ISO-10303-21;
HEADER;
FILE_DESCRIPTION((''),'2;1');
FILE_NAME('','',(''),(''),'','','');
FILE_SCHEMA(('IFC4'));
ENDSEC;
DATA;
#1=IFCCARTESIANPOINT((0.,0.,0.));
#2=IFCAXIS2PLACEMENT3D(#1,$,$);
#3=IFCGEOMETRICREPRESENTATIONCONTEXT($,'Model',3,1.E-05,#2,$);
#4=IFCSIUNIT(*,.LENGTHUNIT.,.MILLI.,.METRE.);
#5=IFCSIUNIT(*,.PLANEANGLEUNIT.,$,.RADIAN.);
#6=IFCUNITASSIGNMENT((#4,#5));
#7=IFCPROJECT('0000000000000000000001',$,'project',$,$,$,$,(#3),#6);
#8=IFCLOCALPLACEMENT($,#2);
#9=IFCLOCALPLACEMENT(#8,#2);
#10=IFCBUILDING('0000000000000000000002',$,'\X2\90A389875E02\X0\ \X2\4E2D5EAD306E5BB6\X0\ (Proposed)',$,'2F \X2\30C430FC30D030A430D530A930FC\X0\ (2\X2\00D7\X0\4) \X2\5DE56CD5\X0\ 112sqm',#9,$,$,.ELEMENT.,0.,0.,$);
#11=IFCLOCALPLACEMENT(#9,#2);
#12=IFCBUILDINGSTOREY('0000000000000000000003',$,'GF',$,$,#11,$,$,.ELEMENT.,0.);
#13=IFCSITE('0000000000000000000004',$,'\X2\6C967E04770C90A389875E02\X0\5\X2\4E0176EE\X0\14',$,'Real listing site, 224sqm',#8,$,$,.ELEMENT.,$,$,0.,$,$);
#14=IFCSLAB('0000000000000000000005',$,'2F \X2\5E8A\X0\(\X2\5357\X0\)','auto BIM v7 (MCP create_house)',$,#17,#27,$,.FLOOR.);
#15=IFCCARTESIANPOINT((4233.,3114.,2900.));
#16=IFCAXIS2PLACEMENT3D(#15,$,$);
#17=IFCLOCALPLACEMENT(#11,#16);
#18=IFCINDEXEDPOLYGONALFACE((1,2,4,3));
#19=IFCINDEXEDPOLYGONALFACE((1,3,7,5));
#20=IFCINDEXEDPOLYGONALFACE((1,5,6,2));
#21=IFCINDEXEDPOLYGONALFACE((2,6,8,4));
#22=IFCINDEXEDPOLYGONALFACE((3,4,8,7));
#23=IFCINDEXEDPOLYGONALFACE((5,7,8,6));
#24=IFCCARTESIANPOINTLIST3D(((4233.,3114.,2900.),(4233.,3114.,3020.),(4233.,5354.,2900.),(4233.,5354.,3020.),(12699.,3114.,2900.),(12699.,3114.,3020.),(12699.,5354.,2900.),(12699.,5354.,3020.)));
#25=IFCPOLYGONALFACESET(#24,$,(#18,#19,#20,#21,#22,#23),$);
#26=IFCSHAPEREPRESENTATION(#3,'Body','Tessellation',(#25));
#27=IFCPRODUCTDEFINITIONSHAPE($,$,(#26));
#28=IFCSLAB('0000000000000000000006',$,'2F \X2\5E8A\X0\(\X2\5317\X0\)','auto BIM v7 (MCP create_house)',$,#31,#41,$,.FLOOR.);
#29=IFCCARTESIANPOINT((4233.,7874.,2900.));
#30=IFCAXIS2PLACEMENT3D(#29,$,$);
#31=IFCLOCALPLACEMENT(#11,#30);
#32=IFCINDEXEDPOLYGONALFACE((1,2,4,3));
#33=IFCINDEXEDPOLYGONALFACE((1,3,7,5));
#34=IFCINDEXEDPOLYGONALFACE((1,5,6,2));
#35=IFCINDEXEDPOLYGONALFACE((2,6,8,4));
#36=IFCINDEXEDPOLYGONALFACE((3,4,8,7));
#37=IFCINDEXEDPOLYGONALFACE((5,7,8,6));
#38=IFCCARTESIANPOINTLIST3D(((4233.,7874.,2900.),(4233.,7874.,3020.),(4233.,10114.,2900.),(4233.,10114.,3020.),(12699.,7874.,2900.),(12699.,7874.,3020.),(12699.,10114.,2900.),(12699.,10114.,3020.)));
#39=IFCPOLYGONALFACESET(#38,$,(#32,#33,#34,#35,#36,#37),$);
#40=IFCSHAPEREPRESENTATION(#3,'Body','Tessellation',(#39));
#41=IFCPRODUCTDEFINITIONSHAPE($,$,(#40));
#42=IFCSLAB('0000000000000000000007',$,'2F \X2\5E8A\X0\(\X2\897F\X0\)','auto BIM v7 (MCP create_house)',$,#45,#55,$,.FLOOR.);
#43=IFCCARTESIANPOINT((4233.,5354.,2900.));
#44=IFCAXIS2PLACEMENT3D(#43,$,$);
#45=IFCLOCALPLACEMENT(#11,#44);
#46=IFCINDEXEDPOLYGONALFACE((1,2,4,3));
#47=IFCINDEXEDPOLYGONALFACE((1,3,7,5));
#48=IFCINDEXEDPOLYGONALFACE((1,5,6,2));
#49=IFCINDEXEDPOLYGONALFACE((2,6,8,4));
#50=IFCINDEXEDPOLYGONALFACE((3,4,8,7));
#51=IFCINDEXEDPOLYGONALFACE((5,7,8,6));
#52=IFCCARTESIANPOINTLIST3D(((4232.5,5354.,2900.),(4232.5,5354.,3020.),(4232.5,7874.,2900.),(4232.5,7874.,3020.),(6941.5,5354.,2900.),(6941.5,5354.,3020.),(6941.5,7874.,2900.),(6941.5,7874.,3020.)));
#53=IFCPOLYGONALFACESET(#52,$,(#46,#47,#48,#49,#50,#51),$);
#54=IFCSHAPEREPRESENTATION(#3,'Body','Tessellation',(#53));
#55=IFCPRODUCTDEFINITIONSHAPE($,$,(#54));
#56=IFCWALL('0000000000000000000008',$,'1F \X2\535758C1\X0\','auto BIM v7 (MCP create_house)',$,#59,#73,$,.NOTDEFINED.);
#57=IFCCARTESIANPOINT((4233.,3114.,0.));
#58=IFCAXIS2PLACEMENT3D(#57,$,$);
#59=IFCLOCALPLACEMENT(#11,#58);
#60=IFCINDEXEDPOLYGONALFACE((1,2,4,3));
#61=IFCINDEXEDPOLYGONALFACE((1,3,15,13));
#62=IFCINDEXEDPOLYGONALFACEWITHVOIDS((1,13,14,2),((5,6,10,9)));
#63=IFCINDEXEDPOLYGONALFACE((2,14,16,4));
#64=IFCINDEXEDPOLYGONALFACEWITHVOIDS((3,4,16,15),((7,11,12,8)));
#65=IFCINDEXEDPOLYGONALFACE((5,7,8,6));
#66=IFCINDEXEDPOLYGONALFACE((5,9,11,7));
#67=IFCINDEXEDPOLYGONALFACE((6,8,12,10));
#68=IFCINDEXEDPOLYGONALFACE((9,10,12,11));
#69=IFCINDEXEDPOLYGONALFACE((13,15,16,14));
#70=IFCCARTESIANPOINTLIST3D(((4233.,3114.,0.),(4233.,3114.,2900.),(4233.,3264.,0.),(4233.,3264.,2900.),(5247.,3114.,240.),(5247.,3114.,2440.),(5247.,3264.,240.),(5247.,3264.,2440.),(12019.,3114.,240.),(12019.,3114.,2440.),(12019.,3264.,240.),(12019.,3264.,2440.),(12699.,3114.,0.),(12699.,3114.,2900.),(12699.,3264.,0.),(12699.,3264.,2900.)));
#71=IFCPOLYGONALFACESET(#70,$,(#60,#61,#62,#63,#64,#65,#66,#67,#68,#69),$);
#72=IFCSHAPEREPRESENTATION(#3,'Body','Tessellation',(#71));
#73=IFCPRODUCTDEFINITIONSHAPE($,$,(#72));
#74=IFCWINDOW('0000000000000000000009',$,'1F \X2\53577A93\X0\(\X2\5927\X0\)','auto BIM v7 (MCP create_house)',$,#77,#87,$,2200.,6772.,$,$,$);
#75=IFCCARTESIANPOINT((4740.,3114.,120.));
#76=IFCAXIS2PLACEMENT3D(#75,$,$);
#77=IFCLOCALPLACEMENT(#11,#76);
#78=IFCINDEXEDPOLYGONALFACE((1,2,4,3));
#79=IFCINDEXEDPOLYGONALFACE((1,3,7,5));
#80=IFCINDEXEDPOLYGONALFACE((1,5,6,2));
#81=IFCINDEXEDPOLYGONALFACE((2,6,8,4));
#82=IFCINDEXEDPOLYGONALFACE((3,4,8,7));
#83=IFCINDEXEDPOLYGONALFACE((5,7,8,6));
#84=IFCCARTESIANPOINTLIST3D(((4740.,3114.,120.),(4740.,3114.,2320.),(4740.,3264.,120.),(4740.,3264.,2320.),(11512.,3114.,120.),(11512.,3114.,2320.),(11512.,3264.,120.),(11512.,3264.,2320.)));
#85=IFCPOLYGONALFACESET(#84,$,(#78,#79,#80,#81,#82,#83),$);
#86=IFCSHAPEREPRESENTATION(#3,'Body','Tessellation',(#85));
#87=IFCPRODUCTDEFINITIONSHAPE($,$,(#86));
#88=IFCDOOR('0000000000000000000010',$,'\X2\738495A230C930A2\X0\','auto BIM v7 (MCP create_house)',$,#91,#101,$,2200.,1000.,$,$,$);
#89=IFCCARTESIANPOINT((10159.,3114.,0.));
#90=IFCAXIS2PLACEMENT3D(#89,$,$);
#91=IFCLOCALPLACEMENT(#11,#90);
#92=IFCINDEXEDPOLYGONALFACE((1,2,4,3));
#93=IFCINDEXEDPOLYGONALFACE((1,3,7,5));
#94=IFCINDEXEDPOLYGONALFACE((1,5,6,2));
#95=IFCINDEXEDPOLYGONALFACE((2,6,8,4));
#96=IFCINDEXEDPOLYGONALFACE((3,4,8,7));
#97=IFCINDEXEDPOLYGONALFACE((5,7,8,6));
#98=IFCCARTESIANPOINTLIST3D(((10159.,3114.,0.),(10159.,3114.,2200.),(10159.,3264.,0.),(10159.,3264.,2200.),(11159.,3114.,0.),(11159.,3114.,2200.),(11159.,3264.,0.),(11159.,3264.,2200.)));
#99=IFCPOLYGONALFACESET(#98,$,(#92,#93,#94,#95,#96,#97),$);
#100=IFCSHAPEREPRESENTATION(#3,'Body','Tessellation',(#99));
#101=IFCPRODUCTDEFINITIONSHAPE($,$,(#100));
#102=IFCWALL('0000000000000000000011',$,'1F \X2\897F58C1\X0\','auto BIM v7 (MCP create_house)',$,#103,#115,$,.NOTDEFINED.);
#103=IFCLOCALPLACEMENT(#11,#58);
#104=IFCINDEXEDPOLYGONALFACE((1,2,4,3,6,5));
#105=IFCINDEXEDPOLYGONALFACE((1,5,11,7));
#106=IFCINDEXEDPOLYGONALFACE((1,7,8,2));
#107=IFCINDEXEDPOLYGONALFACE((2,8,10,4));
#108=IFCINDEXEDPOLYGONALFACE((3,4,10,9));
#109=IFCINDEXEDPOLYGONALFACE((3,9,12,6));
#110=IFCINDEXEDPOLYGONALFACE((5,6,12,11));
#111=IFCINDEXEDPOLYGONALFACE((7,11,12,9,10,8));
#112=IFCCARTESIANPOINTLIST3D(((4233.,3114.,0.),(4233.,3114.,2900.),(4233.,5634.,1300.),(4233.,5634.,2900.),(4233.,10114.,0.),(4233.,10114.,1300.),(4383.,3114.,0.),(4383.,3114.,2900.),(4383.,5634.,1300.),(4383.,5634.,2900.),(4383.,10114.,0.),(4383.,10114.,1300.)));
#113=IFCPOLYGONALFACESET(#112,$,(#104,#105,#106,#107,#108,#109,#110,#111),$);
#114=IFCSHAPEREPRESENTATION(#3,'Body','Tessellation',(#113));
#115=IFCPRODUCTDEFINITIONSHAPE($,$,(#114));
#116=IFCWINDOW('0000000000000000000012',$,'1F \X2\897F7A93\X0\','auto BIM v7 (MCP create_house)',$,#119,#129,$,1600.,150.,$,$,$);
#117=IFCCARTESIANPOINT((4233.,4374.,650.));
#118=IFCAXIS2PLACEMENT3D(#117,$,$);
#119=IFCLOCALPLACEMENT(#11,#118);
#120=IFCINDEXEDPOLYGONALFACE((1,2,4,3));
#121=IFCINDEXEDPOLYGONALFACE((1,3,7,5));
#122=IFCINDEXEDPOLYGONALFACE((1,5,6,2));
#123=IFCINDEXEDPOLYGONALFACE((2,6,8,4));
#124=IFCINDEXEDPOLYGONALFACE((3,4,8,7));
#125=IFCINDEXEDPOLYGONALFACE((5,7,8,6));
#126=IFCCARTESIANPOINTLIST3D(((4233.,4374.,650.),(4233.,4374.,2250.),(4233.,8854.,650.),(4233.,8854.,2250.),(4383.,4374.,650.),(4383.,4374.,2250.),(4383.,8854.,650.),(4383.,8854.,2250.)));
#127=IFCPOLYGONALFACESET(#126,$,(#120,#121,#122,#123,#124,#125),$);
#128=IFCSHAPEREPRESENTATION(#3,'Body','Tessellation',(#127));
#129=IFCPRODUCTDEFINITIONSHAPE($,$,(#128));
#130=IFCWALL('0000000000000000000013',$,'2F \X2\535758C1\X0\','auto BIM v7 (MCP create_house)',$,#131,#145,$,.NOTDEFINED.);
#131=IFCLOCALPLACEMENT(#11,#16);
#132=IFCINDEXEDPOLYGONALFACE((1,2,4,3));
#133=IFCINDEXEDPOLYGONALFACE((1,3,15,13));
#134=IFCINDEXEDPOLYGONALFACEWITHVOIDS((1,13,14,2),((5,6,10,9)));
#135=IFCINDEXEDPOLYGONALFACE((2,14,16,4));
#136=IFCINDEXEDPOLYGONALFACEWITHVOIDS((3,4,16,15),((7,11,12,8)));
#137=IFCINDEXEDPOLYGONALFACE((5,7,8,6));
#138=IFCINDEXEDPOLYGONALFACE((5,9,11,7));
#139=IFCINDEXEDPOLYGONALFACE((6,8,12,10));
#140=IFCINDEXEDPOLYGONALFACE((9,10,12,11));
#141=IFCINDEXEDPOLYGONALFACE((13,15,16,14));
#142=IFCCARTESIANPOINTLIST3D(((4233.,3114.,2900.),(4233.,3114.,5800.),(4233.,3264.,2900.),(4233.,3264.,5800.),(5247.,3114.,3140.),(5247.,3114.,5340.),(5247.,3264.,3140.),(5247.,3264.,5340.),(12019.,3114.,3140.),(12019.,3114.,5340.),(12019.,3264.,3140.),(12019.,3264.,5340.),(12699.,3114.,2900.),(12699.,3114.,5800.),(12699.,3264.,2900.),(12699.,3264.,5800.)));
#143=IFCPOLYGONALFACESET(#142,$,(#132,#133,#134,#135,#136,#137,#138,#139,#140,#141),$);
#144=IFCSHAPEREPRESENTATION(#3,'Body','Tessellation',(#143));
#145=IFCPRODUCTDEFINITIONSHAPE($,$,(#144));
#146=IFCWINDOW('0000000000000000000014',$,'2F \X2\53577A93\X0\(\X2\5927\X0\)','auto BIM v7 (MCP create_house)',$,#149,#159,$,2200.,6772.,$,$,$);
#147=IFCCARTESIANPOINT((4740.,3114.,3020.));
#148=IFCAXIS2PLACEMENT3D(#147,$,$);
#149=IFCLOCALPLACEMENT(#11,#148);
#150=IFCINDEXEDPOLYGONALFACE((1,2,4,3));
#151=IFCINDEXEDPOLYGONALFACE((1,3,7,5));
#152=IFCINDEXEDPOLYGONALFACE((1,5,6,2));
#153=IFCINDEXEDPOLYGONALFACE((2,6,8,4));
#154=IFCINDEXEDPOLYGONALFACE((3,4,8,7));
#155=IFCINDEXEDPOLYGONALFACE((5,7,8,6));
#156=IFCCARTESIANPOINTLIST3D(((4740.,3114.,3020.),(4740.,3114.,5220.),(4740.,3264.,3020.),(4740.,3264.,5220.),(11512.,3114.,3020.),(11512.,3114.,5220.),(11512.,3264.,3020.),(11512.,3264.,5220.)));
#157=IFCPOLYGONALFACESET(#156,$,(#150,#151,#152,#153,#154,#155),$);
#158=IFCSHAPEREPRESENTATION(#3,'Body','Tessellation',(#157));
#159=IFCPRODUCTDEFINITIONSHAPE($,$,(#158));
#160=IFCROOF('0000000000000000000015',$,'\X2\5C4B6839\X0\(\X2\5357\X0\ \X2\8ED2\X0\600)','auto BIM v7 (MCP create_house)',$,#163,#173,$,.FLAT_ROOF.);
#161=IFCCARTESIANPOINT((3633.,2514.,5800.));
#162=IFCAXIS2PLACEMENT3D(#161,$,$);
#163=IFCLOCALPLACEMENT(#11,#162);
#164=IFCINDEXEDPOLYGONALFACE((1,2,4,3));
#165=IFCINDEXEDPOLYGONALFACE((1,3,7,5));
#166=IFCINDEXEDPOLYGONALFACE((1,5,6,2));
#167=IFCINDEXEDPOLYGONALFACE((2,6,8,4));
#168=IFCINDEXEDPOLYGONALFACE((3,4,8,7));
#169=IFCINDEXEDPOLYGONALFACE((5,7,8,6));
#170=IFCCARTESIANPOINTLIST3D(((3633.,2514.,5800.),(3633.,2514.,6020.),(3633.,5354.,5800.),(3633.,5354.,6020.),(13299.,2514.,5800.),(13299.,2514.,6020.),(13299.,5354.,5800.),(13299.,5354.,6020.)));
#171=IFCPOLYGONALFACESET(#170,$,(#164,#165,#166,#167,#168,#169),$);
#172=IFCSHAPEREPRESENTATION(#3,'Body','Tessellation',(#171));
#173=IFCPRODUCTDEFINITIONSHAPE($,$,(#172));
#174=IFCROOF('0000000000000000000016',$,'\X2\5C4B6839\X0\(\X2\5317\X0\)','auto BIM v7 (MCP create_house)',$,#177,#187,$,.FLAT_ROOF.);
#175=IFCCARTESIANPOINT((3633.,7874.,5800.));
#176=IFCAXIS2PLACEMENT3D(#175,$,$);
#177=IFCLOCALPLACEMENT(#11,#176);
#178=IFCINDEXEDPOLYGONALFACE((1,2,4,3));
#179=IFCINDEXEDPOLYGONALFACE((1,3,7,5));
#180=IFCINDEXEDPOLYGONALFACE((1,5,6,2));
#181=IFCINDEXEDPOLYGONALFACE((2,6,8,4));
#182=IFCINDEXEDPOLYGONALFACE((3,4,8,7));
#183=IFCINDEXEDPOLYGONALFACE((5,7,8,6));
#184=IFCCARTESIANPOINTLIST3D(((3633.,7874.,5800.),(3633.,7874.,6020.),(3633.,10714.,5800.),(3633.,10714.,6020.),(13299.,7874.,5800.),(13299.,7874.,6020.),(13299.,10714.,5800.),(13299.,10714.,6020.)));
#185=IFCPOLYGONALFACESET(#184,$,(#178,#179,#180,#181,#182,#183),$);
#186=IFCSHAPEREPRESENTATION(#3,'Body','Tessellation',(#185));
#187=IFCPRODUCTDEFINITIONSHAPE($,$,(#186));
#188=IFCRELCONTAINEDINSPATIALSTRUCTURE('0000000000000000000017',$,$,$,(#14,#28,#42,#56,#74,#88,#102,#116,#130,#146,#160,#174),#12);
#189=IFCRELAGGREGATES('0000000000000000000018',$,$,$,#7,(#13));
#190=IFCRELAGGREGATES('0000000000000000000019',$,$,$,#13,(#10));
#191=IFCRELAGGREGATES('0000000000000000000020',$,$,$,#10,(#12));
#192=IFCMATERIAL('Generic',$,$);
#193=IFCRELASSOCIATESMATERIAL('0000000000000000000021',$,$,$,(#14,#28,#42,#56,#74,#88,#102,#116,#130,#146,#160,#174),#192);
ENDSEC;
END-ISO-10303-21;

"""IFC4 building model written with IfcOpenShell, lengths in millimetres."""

from ifc_helpers import new_model, si_unit, frame, frame_2d, origin, place, context, project, spatial, rectangle, extrude, material, element, fill, save


model = new_model("IFC4")

# Units and contexts
model_context = context("Model", 3, precision=1e-05, world=origin())
ifc_project = project(units=[si_unit("LENGTHUNIT", "METRE", prefix="MILLI"), si_unit("PLANEANGLEUNIT", "RADIAN")], contexts=[model_context])

# Site, building, storey
site_placement = place(None, origin())
site = spatial("IfcSite", under=ifc_project, at=site_placement, Name="沖縄県那覇市5丁目14", ObjectType="Real listing site, 224sqm", CompositionType="ELEMENT", RefElevation=0.0)
building_placement = place(site_placement, origin())
building = spatial("IfcBuilding", under=site, at=building_placement, Name="那覇市 中庭の家 (Proposed)", ObjectType="2F ツーバイフォー (2×4) 工法 112sqm", CompositionType="ELEMENT", ElevationOfRefHeight=0.0, ElevationOfTerrain=0.0)
storey_placement = place(building_placement, origin())
storey = spatial("IfcBuildingStorey", under=building, at=storey_placement, Name="GF", CompositionType="ELEMENT", Elevation=0.0)

# Slabs
ifc_material = material(Name="Generic")
slab_1_placement = place(storey_placement, frame((4233.0, 3114.0, 2900.0)))
element("IfcSlab", 1, at=slab_1_placement, inside=storey, material=ifc_material, Name="2F 床(南)", Description="auto BIM v7 (MCP create_house)", PredefinedType="FLOOR", context=model_context, shape_type="SweptSolid", body=[
    extrude(rectangle(XDim=8466.0, YDim=2240.0, at=frame_2d((4233.0, 1120.0))), frame((4233.0, 3114.0, 2900.0)), (0.0, 0.0, 1.0), 120.0),
])
slab_2_placement = place(storey_placement, frame((4233.0, 7874.0, 2900.0)))
element("IfcSlab", 2, at=slab_2_placement, inside=storey, material=ifc_material, Name="2F 床(北)", Description="auto BIM v7 (MCP create_house)", PredefinedType="FLOOR", context=model_context, shape_type="SweptSolid", body=[
    extrude(rectangle(XDim=8466.0, YDim=2240.0, at=frame_2d((4233.0, 1120.0))), frame((4233.0, 7874.0, 2900.0)), (0.0, 0.0, 1.0), 120.0),
])
slab_3_placement = place(storey_placement, frame((4233.0, 5354.0, 2900.0)))
element("IfcSlab", 3, at=slab_3_placement, inside=storey, material=ifc_material, Name="2F 床(西)", Description="auto BIM v7 (MCP create_house)", PredefinedType="FLOOR", context=model_context, shape_type="SweptSolid", body=[
    extrude(rectangle(XDim=2709.0, YDim=2520.0, at=frame_2d((1354.0, 1260.0))), frame((4233.0, 5354.0, 2900.0)), (0.0, 0.0, 1.0), 120.0),
])

# Wall, openings, window, door
wall_1_placement = place(storey_placement, frame((4233.0, 3114.0, 0.0)))
wall_1 = element("IfcWall", 4, at=wall_1_placement, inside=storey, material=ifc_material, Name="1F 南壁", Description="auto BIM v7 (MCP create_house)", PredefinedType="NOTDEFINED", context=model_context, shape_type="SweptSolid", body=[
    extrude(rectangle(XDim=8466.0, YDim=150.0, at=frame_2d((4233.0, 75.0))), frame((4233.0, 3114.0, 0.0)), (0.0, 0.0, 1.0), 2900.0),
])
opening_1_placement = place(storey_placement, frame((4740.0, 3114.0, 120.0)))
opening_1 = element("IfcOpeningElement", 5, at=opening_1_placement, cuts=wall_1, PredefinedType="NOTDEFINED", context=model_context, shape_type="SweptSolid", body=[
    extrude(rectangle(XDim=6772.0, YDim=150.0, at=frame_2d((3386.0, 75.0))), frame((4740.0, 3114.0, 120.0)), (0.0, 0.0, 1.0), 2200.0),
])
opening_2_placement = place(storey_placement, frame((10159.0, 3114.0, 0.0)))
opening_2 = element("IfcOpeningElement", 6, at=opening_2_placement, cuts=wall_1, PredefinedType="NOTDEFINED", context=model_context, shape_type="SweptSolid", body=[
    extrude(rectangle(XDim=1000.0, YDim=150.0, at=frame_2d((500.0, 75.0))), frame((10159.0, 3114.0, 0.0)), (0.0, 0.0, 1.0), 2200.0),
])
window_1_placement = place(storey_placement, frame((4740.0, 3114.0, 120.0)))
window_1 = element("IfcWindow", 7, at=window_1_placement, inside=storey, material=ifc_material, Name="1F 南窓(大)", Description="auto BIM v7 (MCP create_house)", OverallHeight=2200.0, OverallWidth=6772.0, context=model_context, shape_type="SweptSolid", body=[
    extrude(rectangle(XDim=6772.0, YDim=150.0, at=frame_2d((3386.0, 75.0))), frame((4740.0, 3114.0, 120.0)), (0.0, 0.0, 1.0), 2200.0),
])
fill(opening_1, window_1)
door_placement = place(storey_placement, frame((10159.0, 3114.0, 0.0)))
door = element("IfcDoor", 8, at=door_placement, inside=storey, material=ifc_material, Name="玄関ドア", Description="auto BIM v7 (MCP create_house)", OverallHeight=2200.0, OverallWidth=1000.0, context=model_context, shape_type="SweptSolid", body=[
    extrude(rectangle(XDim=1000.0, YDim=150.0, at=frame_2d((500.0, 75.0))), frame((10159.0, 3114.0, 0.0)), (0.0, 0.0, 1.0), 2200.0),
])
fill(opening_2, door)

# Walls, openings, windows
wall_2_placement = place(storey_placement, frame((4233.0, 3114.0, 0.0)))
wall_2 = element("IfcWall", 9, at=wall_2_placement, inside=storey, material=ifc_material, Name="1F 西壁", Description="auto BIM v7 (MCP create_house)", PredefinedType="NOTDEFINED", context=model_context, shape_type="SweptSolid", body=[
    extrude(rectangle(XDim=150.0, YDim=7000.0, at=frame_2d((75.0, 3500.0))), frame((4233.0, 3114.0, 0.0)), (0.0, 0.0, 1.0), 2900.0),
])
opening_3_placement = place(storey_placement, frame((4233.0, 4374.0, 650.0)))
opening_3 = element("IfcOpeningElement", 10, at=opening_3_placement, cuts=wall_2, PredefinedType="NOTDEFINED", context=model_context, shape_type="SweptSolid", body=[
    extrude(rectangle(XDim=150.0, YDim=4480.0, at=frame_2d((75.0, 2240.0))), frame((4233.0, 4374.0, 650.0)), (0.0, 0.0, 1.0), 1600.0),
])
window_2_placement = place(storey_placement, frame((4233.0, 4374.0, 650.0)))
window_2 = element("IfcWindow", 11, at=window_2_placement, inside=storey, material=ifc_material, Name="1F 西窓", Description="auto BIM v7 (MCP create_house)", OverallHeight=1600.0, OverallWidth=150.0, context=model_context, shape_type="SweptSolid", body=[
    extrude(rectangle(XDim=150.0, YDim=4480.0, at=frame_2d((75.0, 2240.0))), frame((4233.0, 4374.0, 650.0)), (0.0, 0.0, 1.0), 1600.0),
])
fill(opening_3, window_2)
wall_3_placement = place(storey_placement, frame((4233.0, 3114.0, 2900.0)))
wall_3 = element("IfcWall", 12, at=wall_3_placement, inside=storey, material=ifc_material, Name="2F 南壁", Description="auto BIM v7 (MCP create_house)", PredefinedType="NOTDEFINED", context=model_context, shape_type="SweptSolid", body=[
    extrude(rectangle(XDim=8466.0, YDim=150.0, at=frame_2d((4233.0, 75.0))), frame((4233.0, 3114.0, 2900.0)), (0.0, 0.0, 1.0), 2900.0),
])
opening_4_placement = place(storey_placement, frame((4740.0, 3114.0, 3020.0)))
opening_4 = element("IfcOpeningElement", 13, at=opening_4_placement, cuts=wall_3, PredefinedType="NOTDEFINED", context=model_context, shape_type="SweptSolid", body=[
    extrude(rectangle(XDim=6772.0, YDim=150.0, at=frame_2d((3386.0, 75.0))), frame((4740.0, 3114.0, 3020.0)), (0.0, 0.0, 1.0), 2200.0),
])
window_3_placement = place(storey_placement, frame((4740.0, 3114.0, 3020.0)))
window_3 = element("IfcWindow", 14, at=window_3_placement, inside=storey, material=ifc_material, Name="2F 南窓(大)", Description="auto BIM v7 (MCP create_house)", OverallHeight=2200.0, OverallWidth=6772.0, context=model_context, shape_type="SweptSolid", body=[
    extrude(rectangle(XDim=6772.0, YDim=150.0, at=frame_2d((3386.0, 75.0))), frame((4740.0, 3114.0, 3020.0)), (0.0, 0.0, 1.0), 2200.0),
])
fill(opening_4, window_3)

# Roofs
roof_1_placement = place(storey_placement, frame((3633.0, 2514.0, 5800.0)))
element("IfcRoof", 15, at=roof_1_placement, inside=storey, material=ifc_material, Name="屋根(南 軒600)", Description="auto BIM v7 (MCP create_house)", PredefinedType="FLAT_ROOF", context=model_context, shape_type="SweptSolid", body=[
    extrude(rectangle(XDim=9666.0, YDim=2840.0, at=frame_2d((4833.0, 1420.0))), frame((3633.0, 2514.0, 5800.0)), (0.0, 0.0, 1.0), 220.0),
])
roof_2_placement = place(storey_placement, frame((3633.0, 7874.0, 5800.0)))
element("IfcRoof", 16, at=roof_2_placement, inside=storey, material=ifc_material, Name="屋根(北)", Description="auto BIM v7 (MCP create_house)", PredefinedType="FLAT_ROOF", context=model_context, shape_type="SweptSolid", body=[
    extrude(rectangle(XDim=9666.0, YDim=2840.0, at=frame_2d((4833.0, 1420.0))), frame((3633.0, 7874.0, 5800.0)), (0.0, 0.0, 1.0), 220.0),
])

save(model, "model.ifc")
